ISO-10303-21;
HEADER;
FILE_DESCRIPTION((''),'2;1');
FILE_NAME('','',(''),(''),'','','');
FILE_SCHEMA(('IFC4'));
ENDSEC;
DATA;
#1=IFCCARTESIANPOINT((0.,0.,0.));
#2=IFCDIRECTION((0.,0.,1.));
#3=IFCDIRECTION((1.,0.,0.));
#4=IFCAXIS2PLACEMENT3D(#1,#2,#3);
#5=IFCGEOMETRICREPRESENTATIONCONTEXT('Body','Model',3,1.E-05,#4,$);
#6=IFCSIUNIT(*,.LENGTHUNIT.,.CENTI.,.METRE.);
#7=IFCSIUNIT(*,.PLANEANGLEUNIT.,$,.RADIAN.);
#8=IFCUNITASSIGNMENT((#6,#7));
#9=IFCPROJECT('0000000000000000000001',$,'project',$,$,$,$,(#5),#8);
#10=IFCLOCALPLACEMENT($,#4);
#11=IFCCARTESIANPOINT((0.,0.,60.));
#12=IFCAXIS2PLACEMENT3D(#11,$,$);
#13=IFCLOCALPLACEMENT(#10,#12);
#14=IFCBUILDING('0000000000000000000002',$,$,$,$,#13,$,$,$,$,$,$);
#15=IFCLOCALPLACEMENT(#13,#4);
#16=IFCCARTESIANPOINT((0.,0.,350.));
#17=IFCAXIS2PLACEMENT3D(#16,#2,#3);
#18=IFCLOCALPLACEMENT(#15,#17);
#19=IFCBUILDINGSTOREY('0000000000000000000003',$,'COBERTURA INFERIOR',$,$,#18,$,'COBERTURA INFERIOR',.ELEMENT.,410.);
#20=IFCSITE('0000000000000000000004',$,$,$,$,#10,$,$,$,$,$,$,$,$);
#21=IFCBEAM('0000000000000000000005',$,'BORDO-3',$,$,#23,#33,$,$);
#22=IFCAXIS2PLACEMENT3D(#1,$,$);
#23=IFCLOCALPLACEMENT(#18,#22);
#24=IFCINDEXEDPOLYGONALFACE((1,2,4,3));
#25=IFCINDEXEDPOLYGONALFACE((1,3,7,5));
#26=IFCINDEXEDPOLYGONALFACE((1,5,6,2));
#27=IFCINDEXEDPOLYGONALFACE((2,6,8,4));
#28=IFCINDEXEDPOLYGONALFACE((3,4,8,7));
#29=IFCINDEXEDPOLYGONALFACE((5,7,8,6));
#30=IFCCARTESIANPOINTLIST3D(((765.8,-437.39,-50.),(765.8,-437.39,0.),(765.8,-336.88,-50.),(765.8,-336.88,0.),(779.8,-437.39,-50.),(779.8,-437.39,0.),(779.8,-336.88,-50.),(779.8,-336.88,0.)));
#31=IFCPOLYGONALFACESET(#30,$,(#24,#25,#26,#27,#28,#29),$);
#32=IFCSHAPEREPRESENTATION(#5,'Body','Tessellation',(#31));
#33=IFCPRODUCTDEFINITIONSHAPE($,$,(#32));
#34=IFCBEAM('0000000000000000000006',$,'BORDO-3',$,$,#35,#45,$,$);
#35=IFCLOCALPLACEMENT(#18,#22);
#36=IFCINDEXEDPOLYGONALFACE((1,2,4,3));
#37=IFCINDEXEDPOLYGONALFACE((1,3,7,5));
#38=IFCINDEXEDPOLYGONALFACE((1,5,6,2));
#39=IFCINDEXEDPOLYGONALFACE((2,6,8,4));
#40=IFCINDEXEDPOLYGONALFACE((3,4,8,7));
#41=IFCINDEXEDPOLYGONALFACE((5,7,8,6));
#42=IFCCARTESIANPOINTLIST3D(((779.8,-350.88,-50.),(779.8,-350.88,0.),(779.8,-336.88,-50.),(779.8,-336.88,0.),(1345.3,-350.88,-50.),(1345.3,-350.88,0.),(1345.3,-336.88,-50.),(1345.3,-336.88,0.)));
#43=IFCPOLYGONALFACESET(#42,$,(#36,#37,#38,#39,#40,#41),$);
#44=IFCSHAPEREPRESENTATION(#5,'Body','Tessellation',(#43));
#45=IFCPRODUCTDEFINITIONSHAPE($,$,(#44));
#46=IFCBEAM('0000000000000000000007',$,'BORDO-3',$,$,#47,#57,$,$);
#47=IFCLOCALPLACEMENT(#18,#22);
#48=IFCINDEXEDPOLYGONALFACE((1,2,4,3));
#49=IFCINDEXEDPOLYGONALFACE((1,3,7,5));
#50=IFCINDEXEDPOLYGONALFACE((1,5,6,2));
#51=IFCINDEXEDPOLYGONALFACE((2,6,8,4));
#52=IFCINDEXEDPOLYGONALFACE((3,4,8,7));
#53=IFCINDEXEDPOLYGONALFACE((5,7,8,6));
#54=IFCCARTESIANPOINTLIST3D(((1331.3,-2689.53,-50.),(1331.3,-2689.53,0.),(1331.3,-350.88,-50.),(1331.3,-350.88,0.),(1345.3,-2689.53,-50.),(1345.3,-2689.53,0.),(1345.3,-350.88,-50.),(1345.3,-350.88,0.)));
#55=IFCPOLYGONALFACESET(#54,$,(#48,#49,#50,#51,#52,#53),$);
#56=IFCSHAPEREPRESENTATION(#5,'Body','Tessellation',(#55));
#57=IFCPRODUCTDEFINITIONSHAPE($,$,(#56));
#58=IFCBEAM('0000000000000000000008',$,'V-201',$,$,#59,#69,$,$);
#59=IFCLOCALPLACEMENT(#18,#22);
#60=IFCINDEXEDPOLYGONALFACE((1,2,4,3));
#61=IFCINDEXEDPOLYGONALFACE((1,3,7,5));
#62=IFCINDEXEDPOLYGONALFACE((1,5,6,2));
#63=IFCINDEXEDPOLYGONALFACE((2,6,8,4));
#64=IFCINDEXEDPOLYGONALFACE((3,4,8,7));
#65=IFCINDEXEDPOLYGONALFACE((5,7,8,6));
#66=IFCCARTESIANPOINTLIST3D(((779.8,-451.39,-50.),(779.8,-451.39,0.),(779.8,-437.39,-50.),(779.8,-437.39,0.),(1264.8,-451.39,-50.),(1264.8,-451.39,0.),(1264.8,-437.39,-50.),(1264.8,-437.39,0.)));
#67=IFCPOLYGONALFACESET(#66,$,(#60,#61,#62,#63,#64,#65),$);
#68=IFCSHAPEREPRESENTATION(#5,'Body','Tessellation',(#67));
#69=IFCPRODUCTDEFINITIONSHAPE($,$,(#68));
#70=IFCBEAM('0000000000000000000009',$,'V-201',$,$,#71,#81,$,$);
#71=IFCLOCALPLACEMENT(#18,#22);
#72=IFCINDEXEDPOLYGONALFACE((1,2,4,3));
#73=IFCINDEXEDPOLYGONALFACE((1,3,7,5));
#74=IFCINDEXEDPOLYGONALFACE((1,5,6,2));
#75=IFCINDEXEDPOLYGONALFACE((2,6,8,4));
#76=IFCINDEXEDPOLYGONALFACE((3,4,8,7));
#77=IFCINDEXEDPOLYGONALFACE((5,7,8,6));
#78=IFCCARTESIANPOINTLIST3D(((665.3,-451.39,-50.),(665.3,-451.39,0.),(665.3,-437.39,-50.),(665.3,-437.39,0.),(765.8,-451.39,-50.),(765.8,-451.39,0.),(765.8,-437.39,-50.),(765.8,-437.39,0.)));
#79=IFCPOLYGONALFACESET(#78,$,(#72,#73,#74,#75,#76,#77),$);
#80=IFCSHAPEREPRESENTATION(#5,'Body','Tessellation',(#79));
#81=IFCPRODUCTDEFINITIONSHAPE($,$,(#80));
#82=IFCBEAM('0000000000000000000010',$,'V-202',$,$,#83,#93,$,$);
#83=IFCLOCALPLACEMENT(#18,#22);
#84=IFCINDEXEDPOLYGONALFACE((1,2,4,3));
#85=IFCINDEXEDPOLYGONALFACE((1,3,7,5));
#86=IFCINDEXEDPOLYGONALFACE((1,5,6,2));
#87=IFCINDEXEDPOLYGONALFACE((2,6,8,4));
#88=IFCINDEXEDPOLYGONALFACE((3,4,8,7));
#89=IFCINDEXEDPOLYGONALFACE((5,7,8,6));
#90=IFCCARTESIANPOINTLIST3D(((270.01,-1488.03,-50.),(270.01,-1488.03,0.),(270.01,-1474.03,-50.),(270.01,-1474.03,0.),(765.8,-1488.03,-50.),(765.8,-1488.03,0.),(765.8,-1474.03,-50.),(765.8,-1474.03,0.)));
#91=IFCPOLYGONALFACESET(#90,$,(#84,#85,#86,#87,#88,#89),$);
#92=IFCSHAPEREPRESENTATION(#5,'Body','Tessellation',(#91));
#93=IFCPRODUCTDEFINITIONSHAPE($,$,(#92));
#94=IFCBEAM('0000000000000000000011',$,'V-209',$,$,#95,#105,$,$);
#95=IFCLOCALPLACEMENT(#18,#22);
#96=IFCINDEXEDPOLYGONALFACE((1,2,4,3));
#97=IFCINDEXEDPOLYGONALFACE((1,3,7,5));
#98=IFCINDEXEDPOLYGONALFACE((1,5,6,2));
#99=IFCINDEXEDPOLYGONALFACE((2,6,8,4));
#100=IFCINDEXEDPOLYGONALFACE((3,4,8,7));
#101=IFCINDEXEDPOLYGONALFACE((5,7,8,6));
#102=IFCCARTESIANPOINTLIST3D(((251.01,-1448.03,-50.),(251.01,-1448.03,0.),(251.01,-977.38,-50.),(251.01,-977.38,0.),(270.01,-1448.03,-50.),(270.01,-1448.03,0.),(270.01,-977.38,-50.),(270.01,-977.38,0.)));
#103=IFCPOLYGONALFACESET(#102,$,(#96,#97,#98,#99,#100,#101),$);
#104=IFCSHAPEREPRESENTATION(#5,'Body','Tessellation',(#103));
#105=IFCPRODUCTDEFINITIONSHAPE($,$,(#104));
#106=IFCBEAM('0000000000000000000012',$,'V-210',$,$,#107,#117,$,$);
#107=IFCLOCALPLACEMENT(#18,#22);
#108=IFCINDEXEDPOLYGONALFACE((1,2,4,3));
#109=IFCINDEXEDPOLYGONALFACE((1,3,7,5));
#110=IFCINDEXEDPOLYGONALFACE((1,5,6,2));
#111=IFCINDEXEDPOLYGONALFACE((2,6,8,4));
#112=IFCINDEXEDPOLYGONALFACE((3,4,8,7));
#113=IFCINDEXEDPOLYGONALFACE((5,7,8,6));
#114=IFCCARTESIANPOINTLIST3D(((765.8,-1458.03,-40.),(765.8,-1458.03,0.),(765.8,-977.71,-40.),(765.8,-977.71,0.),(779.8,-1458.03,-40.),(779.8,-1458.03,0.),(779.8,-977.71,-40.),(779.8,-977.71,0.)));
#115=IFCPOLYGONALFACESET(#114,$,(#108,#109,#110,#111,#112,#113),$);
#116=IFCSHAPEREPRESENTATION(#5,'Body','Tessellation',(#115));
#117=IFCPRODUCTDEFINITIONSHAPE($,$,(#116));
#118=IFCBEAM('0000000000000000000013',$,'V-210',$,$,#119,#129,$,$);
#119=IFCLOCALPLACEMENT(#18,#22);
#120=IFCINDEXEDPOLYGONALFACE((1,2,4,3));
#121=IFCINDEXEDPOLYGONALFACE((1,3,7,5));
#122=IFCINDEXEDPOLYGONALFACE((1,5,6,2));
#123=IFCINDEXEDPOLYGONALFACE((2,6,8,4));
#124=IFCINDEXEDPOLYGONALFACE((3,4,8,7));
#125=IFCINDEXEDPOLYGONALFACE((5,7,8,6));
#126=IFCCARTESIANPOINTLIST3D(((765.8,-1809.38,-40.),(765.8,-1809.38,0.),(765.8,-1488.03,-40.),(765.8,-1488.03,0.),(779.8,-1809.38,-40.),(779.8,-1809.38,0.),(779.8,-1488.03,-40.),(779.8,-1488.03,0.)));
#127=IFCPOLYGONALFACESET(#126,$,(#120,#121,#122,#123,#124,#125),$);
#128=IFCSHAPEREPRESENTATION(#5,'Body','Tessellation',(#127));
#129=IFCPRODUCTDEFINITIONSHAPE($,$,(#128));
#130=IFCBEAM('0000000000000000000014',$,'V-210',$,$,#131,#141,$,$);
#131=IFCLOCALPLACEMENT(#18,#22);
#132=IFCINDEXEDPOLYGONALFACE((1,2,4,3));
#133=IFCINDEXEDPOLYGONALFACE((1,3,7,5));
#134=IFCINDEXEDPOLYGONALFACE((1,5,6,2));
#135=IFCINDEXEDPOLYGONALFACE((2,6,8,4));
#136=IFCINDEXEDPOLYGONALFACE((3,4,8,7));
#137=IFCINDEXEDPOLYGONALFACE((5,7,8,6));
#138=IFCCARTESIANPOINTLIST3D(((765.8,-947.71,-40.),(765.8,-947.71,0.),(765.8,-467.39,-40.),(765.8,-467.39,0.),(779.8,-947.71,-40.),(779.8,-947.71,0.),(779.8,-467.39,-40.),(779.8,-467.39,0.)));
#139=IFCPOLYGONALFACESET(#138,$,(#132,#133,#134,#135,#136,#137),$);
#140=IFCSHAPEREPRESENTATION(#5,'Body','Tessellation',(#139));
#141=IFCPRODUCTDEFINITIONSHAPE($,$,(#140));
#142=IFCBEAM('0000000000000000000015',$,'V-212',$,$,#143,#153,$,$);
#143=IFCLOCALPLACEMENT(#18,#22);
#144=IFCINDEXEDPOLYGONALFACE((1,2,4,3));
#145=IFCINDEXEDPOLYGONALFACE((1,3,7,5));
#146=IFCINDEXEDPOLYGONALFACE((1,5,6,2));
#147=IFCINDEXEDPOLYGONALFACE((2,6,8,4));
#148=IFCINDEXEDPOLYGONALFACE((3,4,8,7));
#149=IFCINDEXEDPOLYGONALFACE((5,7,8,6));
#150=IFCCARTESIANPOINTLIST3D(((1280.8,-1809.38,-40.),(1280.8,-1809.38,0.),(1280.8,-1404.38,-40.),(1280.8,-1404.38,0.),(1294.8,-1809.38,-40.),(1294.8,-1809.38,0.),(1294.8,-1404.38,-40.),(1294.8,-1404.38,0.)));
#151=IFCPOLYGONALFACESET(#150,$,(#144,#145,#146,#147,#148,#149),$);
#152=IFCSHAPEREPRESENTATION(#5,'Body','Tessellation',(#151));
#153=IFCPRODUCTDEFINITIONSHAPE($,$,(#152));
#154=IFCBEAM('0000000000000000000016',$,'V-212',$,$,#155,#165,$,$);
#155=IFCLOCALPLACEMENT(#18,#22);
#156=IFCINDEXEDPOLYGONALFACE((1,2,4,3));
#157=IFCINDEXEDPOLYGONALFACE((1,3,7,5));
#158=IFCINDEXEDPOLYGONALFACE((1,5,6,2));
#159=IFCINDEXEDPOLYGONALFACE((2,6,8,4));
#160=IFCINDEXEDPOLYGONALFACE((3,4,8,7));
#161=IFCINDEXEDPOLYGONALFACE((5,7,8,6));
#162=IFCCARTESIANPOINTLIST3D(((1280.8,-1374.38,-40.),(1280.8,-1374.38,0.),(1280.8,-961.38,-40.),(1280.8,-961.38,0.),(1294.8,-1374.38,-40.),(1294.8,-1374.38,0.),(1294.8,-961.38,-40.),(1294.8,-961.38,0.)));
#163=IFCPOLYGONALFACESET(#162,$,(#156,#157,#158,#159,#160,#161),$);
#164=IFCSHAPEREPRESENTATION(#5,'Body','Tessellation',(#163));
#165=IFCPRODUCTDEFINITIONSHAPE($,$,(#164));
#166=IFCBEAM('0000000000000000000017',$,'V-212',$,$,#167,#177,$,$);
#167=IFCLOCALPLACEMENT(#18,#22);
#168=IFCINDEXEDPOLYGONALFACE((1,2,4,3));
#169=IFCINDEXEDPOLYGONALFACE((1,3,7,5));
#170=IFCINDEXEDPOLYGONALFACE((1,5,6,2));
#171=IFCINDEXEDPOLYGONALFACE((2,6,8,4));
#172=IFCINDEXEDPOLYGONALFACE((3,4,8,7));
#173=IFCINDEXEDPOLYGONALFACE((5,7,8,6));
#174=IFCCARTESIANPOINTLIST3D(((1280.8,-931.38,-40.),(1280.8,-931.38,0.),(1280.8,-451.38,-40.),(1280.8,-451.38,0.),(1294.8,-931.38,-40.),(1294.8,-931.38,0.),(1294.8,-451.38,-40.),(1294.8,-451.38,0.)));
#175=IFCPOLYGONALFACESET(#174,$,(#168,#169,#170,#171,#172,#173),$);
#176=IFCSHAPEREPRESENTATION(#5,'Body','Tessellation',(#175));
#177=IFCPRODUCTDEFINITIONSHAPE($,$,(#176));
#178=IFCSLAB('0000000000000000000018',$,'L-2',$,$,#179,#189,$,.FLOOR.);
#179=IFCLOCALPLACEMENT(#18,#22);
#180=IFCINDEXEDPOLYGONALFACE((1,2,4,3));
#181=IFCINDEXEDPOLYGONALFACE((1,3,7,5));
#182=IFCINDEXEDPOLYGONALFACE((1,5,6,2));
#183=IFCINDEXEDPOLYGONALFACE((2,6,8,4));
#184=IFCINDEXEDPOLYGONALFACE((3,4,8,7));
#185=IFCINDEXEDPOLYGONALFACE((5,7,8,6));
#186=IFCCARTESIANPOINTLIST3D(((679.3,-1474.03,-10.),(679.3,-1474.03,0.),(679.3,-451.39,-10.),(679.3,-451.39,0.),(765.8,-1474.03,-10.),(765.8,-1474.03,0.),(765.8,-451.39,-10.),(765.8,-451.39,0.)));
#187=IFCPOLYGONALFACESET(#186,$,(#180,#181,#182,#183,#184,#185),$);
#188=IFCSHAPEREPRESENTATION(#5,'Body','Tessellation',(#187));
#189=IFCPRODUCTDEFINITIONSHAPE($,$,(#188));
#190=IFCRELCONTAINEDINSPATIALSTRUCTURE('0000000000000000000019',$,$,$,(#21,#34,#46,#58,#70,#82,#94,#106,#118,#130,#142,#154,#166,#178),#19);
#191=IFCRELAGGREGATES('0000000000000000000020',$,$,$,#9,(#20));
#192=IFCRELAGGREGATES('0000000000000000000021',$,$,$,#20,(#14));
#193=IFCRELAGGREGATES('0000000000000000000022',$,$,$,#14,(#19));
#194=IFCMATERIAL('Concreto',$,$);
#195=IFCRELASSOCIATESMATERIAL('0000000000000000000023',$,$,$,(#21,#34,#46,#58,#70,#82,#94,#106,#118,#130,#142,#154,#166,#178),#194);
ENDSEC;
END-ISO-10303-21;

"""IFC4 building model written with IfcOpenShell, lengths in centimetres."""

from ifc_helpers import new_model, si_unit, frame, origin_with_axes, origin_2d_with_axis, place, context, project, spatial, polyline, rectangle, outline, extrude, material, element, save


model = new_model("IFC4")

# Units and contexts
model_context = context("Model", 3, precision=1e-05, world=origin_with_axes(), identifier="Body")
ifc_project = project(units=[si_unit("LENGTHUNIT", "METRE", prefix="CENTI"), si_unit("PLANEANGLEUNIT", "RADIAN")], contexts=[model_context])

# Site, building, storey
site_placement = place(None, origin_with_axes())
site = spatial("IfcSite", under=ifc_project, at=site_placement)
building_placement = place(site_placement, frame((0.0, 0.0, 60.0)))
building = spatial("IfcBuilding", under=site, at=building_placement)
placement = place(building_placement, origin_with_axes())
storey_placement = place(placement, frame((0.0, 0.0, 350.0), z_axis=(0.0, 0.0, 1.0), x_axis=(1.0, 0.0, 0.0)))
storey = spatial("IfcBuildingStorey", under=building, at=storey_placement, Name="COBERTURA INFERIOR", LongName="COBERTURA INFERIOR", CompositionType="ELEMENT", Elevation=410.0)

# Shared definitions
ifc_material = material(Name="Concreto")

# Beams
beam_1_placement = place(storey_placement, frame((772.8, -387.13, 0.0), z_axis=(0.0, 0.0, 1.0), x_axis=(1.0, 0.0, 0.0)))
element("IfcBeam", 1, at=beam_1_placement, inside=storey, material=ifc_material, Name="BORDO-3", context=model_context, shape_type="SolidModel", body=[
    extrude(rectangle(XDim=14.0, YDim=50.0, at=origin_2d_with_axis()), frame((0.0, 50.26, -25.0), z_axis=(0.0, -1.0, 0.0), x_axis=(1.0, 0.0, 0.0)), (0.0, 0.0, 1.0), 100.51),
])
beam_2_placement = place(storey_placement, frame((1062.55, -343.88, 0.0), z_axis=(0.0, 0.0, 1.0), x_axis=(1.0, 0.0, 0.0)))
element("IfcBeam", 2, at=beam_2_placement, inside=storey, material=ifc_material, Name="BORDO-3", context=model_context, shape_type="SolidModel", body=[
    extrude(rectangle(XDim=14.0, YDim=50.0, at=origin_2d_with_axis()), frame((282.75, 0.0, -25.0), z_axis=(-1.0, 0.0, 0.0), x_axis=(0.0, 1.0, 0.0)), (0.0, 0.0, 1.0), 565.5),
])
beam_3_placement = place(storey_placement, frame((1338.3, -1520.2, 0.0), z_axis=(0.0, 0.0, 1.0), x_axis=(1.0, 0.0, 0.0)))
element("IfcBeam", 3, at=beam_3_placement, inside=storey, material=ifc_material, Name="BORDO-3", context=model_context, shape_type="SolidModel", body=[
    extrude(rectangle(XDim=14.0, YDim=50.0, at=origin_2d_with_axis()), frame((0.0, -1169.33, -25.0), z_axis=(0.0, 1.0, 0.0), x_axis=(1.0, 0.0, 0.0)), (0.0, 0.0, 1.0), 2338.65),
])
beam_4_placement = place(storey_placement, frame((1022.3, -444.39, 0.0), z_axis=(0.0, 0.0, 1.0), x_axis=(1.0, 0.0, 0.0)))
element("IfcBeam", 4, at=beam_4_placement, inside=storey, material=ifc_material, Name="V-201", context=model_context, shape_type="SolidModel", body=[
    extrude(rectangle(XDim=14.0, YDim=50.0, at=origin_2d_with_axis()), frame((-242.5, 0.0, -25.0), z_axis=(1.0, 0.0, 0.0), x_axis=(0.0, 1.0, 0.0)), (0.0, 0.0, 1.0), 485.0),
])
beam_5_placement = place(storey_placement, frame((715.55, -444.39, 0.0), z_axis=(0.0, 0.0, 1.0), x_axis=(1.0, 0.0, 0.0)))
element("IfcBeam", 5, at=beam_5_placement, inside=storey, material=ifc_material, Name="V-201", context=model_context, shape_type="SolidModel", body=[
    extrude(rectangle(XDim=14.0, YDim=50.0, at=origin_2d_with_axis()), frame((-50.25, 0.0, -25.0), z_axis=(1.0, 0.0, 0.0), x_axis=(0.0, -1.0, 0.0)), (0.0, 0.0, 1.0), 100.5),
])
beam_6_placement = place(storey_placement, frame((517.9, -1481.03, 0.0), z_axis=(0.0, 0.0, 1.0), x_axis=(1.0, 0.0, 0.0)))
element("IfcBeam", 6, at=beam_6_placement, inside=storey, material=ifc_material, Name="V-202", context=model_context, shape_type="SolidModel", body=[
    extrude(rectangle(XDim=14.0, YDim=50.0, at=origin_2d_with_axis()), frame((-247.9, 0.0, -25.0), z_axis=(1.0, 0.0, 0.0), x_axis=(0.0, -1.0, 0.0)), (0.0, 0.0, 1.0), 495.79),
])
beam_7_placement = place(storey_placement, frame((260.51, -1212.7, 0.0), z_axis=(0.0, 0.0, 1.0), x_axis=(1.0, 0.0, 0.0)))
element("IfcBeam", 7, at=beam_7_placement, inside=storey, material=ifc_material, Name="V-209", context=model_context, shape_type="SolidModel", body=[
    extrude(rectangle(XDim=19.0, YDim=50.0, at=origin_2d_with_axis()), frame((0.0, -235.32, -25.0), z_axis=(0.0, 1.0, 0.0), x_axis=(1.0, 0.0, 0.0)), (0.0, 0.0, 1.0), 470.65),
])
beam_8_placement = place(storey_placement, frame((772.8, -1217.87, 0.0), z_axis=(0.0, 0.0, 1.0), x_axis=(1.0, 0.0, 0.0)))
element("IfcBeam", 8, at=beam_8_placement, inside=storey, material=ifc_material, Name="V-210", context=model_context, shape_type="SolidModel", body=[
    extrude(rectangle(XDim=14.0, YDim=40.0, at=origin_2d_with_axis()), frame((0.0, -240.16, -20.0), z_axis=(0.0, 1.0, 0.0), x_axis=(1.0, 0.0, 0.0)), (0.0, 0.0, 1.0), 480.32),
])
beam_9_placement = place(storey_placement, frame((772.8, -1648.7, 0.0), z_axis=(0.0, 0.0, 1.0), x_axis=(1.0, 0.0, 0.0)))
element("IfcBeam", 9, at=beam_9_placement, inside=storey, material=ifc_material, Name="V-210", context=model_context, shape_type="SolidModel", body=[
    extrude(rectangle(XDim=14.0, YDim=40.0, at=origin_2d_with_axis()), frame((0.0, -160.68, -20.0), z_axis=(0.0, 1.0, 0.0), x_axis=(1.0, 0.0, 0.0)), (0.0, 0.0, 1.0), 321.35),
])
beam_10_placement = place(storey_placement, frame((772.8, -707.55, 0.0), z_axis=(0.0, 0.0, 1.0), x_axis=(1.0, 0.0, 0.0)))
element("IfcBeam", 10, at=beam_10_placement, inside=storey, material=ifc_material, Name="V-210", context=model_context, shape_type="SolidModel", body=[
    extrude(rectangle(XDim=14.0, YDim=40.0, at=origin_2d_with_axis()), frame((0.0, -240.16, -20.0), z_axis=(0.0, 1.0, 0.0), x_axis=(1.0, 0.0, 0.0)), (0.0, 0.0, 1.0), 480.32),
])
beam_11_placement = place(storey_placement, frame((1287.8, -1606.88, 0.0), z_axis=(0.0, 0.0, 1.0), x_axis=(1.0, 0.0, 0.0)))
element("IfcBeam", 11, at=beam_11_placement, inside=storey, material=ifc_material, Name="V-212", context=model_context, shape_type="SolidModel", body=[
    extrude(rectangle(XDim=14.0, YDim=40.0, at=origin_2d_with_axis()), frame((0.0, -202.5, -20.0), z_axis=(0.0, 1.0, 0.0), x_axis=(1.0, 0.0, 0.0)), (0.0, 0.0, 1.0), 405.0),
])
beam_12_placement = place(storey_placement, frame((1287.8, -1167.88, 0.0), z_axis=(0.0, 0.0, 1.0), x_axis=(1.0, 0.0, 0.0)))
element("IfcBeam", 12, at=beam_12_placement, inside=storey, material=ifc_material, Name="V-212", context=model_context, shape_type="SolidModel", body=[
    extrude(rectangle(XDim=14.0, YDim=40.0, at=origin_2d_with_axis()), frame((0.0, -206.5, -20.0), z_axis=(0.0, 1.0, 0.0), x_axis=(1.0, 0.0, 0.0)), (0.0, 0.0, 1.0), 413.0),
])
beam_13_placement = place(storey_placement, frame((1287.8, -691.38, 0.0), z_axis=(0.0, 0.0, 1.0), x_axis=(1.0, 0.0, 0.0)))
element("IfcBeam", 13, at=beam_13_placement, inside=storey, material=ifc_material, Name="V-212", context=model_context, shape_type="SolidModel", body=[
    extrude(rectangle(XDim=14.0, YDim=40.0, at=origin_2d_with_axis()), frame((0.0, -240.0, -20.0), z_axis=(0.0, 1.0, 0.0), x_axis=(1.0, 0.0, 0.0)), (0.0, 0.0, 1.0), 480.0),
])

# Slab
slab_1_placement = place(storey_placement, frame((722.55, -962.71, 0.0), z_axis=(0.0, 0.0, 1.0), x_axis=(1.0, 0.0, 0.0)))
element("IfcSlab", 14, at=slab_1_placement, inside=storey, material=ifc_material, Name="L-2", PredefinedType="FLOOR", context=model_context, shape_type="SolidModel", body=[
    extrude(outline(polyline([(43.25, 511.32), (-43.25, 511.32), (-43.25, -511.32), (43.25, -511.32), (43.25, 511.32), (43.25, 511.32)])), frame((0.0, 0.0, -10.0), z_axis=(0.0, 0.0, 1.0), x_axis=(1.0, 0.0, 0.0)), (0.0, 0.0, 1.0), 10.0),
])

save(model, "model.ifc")
